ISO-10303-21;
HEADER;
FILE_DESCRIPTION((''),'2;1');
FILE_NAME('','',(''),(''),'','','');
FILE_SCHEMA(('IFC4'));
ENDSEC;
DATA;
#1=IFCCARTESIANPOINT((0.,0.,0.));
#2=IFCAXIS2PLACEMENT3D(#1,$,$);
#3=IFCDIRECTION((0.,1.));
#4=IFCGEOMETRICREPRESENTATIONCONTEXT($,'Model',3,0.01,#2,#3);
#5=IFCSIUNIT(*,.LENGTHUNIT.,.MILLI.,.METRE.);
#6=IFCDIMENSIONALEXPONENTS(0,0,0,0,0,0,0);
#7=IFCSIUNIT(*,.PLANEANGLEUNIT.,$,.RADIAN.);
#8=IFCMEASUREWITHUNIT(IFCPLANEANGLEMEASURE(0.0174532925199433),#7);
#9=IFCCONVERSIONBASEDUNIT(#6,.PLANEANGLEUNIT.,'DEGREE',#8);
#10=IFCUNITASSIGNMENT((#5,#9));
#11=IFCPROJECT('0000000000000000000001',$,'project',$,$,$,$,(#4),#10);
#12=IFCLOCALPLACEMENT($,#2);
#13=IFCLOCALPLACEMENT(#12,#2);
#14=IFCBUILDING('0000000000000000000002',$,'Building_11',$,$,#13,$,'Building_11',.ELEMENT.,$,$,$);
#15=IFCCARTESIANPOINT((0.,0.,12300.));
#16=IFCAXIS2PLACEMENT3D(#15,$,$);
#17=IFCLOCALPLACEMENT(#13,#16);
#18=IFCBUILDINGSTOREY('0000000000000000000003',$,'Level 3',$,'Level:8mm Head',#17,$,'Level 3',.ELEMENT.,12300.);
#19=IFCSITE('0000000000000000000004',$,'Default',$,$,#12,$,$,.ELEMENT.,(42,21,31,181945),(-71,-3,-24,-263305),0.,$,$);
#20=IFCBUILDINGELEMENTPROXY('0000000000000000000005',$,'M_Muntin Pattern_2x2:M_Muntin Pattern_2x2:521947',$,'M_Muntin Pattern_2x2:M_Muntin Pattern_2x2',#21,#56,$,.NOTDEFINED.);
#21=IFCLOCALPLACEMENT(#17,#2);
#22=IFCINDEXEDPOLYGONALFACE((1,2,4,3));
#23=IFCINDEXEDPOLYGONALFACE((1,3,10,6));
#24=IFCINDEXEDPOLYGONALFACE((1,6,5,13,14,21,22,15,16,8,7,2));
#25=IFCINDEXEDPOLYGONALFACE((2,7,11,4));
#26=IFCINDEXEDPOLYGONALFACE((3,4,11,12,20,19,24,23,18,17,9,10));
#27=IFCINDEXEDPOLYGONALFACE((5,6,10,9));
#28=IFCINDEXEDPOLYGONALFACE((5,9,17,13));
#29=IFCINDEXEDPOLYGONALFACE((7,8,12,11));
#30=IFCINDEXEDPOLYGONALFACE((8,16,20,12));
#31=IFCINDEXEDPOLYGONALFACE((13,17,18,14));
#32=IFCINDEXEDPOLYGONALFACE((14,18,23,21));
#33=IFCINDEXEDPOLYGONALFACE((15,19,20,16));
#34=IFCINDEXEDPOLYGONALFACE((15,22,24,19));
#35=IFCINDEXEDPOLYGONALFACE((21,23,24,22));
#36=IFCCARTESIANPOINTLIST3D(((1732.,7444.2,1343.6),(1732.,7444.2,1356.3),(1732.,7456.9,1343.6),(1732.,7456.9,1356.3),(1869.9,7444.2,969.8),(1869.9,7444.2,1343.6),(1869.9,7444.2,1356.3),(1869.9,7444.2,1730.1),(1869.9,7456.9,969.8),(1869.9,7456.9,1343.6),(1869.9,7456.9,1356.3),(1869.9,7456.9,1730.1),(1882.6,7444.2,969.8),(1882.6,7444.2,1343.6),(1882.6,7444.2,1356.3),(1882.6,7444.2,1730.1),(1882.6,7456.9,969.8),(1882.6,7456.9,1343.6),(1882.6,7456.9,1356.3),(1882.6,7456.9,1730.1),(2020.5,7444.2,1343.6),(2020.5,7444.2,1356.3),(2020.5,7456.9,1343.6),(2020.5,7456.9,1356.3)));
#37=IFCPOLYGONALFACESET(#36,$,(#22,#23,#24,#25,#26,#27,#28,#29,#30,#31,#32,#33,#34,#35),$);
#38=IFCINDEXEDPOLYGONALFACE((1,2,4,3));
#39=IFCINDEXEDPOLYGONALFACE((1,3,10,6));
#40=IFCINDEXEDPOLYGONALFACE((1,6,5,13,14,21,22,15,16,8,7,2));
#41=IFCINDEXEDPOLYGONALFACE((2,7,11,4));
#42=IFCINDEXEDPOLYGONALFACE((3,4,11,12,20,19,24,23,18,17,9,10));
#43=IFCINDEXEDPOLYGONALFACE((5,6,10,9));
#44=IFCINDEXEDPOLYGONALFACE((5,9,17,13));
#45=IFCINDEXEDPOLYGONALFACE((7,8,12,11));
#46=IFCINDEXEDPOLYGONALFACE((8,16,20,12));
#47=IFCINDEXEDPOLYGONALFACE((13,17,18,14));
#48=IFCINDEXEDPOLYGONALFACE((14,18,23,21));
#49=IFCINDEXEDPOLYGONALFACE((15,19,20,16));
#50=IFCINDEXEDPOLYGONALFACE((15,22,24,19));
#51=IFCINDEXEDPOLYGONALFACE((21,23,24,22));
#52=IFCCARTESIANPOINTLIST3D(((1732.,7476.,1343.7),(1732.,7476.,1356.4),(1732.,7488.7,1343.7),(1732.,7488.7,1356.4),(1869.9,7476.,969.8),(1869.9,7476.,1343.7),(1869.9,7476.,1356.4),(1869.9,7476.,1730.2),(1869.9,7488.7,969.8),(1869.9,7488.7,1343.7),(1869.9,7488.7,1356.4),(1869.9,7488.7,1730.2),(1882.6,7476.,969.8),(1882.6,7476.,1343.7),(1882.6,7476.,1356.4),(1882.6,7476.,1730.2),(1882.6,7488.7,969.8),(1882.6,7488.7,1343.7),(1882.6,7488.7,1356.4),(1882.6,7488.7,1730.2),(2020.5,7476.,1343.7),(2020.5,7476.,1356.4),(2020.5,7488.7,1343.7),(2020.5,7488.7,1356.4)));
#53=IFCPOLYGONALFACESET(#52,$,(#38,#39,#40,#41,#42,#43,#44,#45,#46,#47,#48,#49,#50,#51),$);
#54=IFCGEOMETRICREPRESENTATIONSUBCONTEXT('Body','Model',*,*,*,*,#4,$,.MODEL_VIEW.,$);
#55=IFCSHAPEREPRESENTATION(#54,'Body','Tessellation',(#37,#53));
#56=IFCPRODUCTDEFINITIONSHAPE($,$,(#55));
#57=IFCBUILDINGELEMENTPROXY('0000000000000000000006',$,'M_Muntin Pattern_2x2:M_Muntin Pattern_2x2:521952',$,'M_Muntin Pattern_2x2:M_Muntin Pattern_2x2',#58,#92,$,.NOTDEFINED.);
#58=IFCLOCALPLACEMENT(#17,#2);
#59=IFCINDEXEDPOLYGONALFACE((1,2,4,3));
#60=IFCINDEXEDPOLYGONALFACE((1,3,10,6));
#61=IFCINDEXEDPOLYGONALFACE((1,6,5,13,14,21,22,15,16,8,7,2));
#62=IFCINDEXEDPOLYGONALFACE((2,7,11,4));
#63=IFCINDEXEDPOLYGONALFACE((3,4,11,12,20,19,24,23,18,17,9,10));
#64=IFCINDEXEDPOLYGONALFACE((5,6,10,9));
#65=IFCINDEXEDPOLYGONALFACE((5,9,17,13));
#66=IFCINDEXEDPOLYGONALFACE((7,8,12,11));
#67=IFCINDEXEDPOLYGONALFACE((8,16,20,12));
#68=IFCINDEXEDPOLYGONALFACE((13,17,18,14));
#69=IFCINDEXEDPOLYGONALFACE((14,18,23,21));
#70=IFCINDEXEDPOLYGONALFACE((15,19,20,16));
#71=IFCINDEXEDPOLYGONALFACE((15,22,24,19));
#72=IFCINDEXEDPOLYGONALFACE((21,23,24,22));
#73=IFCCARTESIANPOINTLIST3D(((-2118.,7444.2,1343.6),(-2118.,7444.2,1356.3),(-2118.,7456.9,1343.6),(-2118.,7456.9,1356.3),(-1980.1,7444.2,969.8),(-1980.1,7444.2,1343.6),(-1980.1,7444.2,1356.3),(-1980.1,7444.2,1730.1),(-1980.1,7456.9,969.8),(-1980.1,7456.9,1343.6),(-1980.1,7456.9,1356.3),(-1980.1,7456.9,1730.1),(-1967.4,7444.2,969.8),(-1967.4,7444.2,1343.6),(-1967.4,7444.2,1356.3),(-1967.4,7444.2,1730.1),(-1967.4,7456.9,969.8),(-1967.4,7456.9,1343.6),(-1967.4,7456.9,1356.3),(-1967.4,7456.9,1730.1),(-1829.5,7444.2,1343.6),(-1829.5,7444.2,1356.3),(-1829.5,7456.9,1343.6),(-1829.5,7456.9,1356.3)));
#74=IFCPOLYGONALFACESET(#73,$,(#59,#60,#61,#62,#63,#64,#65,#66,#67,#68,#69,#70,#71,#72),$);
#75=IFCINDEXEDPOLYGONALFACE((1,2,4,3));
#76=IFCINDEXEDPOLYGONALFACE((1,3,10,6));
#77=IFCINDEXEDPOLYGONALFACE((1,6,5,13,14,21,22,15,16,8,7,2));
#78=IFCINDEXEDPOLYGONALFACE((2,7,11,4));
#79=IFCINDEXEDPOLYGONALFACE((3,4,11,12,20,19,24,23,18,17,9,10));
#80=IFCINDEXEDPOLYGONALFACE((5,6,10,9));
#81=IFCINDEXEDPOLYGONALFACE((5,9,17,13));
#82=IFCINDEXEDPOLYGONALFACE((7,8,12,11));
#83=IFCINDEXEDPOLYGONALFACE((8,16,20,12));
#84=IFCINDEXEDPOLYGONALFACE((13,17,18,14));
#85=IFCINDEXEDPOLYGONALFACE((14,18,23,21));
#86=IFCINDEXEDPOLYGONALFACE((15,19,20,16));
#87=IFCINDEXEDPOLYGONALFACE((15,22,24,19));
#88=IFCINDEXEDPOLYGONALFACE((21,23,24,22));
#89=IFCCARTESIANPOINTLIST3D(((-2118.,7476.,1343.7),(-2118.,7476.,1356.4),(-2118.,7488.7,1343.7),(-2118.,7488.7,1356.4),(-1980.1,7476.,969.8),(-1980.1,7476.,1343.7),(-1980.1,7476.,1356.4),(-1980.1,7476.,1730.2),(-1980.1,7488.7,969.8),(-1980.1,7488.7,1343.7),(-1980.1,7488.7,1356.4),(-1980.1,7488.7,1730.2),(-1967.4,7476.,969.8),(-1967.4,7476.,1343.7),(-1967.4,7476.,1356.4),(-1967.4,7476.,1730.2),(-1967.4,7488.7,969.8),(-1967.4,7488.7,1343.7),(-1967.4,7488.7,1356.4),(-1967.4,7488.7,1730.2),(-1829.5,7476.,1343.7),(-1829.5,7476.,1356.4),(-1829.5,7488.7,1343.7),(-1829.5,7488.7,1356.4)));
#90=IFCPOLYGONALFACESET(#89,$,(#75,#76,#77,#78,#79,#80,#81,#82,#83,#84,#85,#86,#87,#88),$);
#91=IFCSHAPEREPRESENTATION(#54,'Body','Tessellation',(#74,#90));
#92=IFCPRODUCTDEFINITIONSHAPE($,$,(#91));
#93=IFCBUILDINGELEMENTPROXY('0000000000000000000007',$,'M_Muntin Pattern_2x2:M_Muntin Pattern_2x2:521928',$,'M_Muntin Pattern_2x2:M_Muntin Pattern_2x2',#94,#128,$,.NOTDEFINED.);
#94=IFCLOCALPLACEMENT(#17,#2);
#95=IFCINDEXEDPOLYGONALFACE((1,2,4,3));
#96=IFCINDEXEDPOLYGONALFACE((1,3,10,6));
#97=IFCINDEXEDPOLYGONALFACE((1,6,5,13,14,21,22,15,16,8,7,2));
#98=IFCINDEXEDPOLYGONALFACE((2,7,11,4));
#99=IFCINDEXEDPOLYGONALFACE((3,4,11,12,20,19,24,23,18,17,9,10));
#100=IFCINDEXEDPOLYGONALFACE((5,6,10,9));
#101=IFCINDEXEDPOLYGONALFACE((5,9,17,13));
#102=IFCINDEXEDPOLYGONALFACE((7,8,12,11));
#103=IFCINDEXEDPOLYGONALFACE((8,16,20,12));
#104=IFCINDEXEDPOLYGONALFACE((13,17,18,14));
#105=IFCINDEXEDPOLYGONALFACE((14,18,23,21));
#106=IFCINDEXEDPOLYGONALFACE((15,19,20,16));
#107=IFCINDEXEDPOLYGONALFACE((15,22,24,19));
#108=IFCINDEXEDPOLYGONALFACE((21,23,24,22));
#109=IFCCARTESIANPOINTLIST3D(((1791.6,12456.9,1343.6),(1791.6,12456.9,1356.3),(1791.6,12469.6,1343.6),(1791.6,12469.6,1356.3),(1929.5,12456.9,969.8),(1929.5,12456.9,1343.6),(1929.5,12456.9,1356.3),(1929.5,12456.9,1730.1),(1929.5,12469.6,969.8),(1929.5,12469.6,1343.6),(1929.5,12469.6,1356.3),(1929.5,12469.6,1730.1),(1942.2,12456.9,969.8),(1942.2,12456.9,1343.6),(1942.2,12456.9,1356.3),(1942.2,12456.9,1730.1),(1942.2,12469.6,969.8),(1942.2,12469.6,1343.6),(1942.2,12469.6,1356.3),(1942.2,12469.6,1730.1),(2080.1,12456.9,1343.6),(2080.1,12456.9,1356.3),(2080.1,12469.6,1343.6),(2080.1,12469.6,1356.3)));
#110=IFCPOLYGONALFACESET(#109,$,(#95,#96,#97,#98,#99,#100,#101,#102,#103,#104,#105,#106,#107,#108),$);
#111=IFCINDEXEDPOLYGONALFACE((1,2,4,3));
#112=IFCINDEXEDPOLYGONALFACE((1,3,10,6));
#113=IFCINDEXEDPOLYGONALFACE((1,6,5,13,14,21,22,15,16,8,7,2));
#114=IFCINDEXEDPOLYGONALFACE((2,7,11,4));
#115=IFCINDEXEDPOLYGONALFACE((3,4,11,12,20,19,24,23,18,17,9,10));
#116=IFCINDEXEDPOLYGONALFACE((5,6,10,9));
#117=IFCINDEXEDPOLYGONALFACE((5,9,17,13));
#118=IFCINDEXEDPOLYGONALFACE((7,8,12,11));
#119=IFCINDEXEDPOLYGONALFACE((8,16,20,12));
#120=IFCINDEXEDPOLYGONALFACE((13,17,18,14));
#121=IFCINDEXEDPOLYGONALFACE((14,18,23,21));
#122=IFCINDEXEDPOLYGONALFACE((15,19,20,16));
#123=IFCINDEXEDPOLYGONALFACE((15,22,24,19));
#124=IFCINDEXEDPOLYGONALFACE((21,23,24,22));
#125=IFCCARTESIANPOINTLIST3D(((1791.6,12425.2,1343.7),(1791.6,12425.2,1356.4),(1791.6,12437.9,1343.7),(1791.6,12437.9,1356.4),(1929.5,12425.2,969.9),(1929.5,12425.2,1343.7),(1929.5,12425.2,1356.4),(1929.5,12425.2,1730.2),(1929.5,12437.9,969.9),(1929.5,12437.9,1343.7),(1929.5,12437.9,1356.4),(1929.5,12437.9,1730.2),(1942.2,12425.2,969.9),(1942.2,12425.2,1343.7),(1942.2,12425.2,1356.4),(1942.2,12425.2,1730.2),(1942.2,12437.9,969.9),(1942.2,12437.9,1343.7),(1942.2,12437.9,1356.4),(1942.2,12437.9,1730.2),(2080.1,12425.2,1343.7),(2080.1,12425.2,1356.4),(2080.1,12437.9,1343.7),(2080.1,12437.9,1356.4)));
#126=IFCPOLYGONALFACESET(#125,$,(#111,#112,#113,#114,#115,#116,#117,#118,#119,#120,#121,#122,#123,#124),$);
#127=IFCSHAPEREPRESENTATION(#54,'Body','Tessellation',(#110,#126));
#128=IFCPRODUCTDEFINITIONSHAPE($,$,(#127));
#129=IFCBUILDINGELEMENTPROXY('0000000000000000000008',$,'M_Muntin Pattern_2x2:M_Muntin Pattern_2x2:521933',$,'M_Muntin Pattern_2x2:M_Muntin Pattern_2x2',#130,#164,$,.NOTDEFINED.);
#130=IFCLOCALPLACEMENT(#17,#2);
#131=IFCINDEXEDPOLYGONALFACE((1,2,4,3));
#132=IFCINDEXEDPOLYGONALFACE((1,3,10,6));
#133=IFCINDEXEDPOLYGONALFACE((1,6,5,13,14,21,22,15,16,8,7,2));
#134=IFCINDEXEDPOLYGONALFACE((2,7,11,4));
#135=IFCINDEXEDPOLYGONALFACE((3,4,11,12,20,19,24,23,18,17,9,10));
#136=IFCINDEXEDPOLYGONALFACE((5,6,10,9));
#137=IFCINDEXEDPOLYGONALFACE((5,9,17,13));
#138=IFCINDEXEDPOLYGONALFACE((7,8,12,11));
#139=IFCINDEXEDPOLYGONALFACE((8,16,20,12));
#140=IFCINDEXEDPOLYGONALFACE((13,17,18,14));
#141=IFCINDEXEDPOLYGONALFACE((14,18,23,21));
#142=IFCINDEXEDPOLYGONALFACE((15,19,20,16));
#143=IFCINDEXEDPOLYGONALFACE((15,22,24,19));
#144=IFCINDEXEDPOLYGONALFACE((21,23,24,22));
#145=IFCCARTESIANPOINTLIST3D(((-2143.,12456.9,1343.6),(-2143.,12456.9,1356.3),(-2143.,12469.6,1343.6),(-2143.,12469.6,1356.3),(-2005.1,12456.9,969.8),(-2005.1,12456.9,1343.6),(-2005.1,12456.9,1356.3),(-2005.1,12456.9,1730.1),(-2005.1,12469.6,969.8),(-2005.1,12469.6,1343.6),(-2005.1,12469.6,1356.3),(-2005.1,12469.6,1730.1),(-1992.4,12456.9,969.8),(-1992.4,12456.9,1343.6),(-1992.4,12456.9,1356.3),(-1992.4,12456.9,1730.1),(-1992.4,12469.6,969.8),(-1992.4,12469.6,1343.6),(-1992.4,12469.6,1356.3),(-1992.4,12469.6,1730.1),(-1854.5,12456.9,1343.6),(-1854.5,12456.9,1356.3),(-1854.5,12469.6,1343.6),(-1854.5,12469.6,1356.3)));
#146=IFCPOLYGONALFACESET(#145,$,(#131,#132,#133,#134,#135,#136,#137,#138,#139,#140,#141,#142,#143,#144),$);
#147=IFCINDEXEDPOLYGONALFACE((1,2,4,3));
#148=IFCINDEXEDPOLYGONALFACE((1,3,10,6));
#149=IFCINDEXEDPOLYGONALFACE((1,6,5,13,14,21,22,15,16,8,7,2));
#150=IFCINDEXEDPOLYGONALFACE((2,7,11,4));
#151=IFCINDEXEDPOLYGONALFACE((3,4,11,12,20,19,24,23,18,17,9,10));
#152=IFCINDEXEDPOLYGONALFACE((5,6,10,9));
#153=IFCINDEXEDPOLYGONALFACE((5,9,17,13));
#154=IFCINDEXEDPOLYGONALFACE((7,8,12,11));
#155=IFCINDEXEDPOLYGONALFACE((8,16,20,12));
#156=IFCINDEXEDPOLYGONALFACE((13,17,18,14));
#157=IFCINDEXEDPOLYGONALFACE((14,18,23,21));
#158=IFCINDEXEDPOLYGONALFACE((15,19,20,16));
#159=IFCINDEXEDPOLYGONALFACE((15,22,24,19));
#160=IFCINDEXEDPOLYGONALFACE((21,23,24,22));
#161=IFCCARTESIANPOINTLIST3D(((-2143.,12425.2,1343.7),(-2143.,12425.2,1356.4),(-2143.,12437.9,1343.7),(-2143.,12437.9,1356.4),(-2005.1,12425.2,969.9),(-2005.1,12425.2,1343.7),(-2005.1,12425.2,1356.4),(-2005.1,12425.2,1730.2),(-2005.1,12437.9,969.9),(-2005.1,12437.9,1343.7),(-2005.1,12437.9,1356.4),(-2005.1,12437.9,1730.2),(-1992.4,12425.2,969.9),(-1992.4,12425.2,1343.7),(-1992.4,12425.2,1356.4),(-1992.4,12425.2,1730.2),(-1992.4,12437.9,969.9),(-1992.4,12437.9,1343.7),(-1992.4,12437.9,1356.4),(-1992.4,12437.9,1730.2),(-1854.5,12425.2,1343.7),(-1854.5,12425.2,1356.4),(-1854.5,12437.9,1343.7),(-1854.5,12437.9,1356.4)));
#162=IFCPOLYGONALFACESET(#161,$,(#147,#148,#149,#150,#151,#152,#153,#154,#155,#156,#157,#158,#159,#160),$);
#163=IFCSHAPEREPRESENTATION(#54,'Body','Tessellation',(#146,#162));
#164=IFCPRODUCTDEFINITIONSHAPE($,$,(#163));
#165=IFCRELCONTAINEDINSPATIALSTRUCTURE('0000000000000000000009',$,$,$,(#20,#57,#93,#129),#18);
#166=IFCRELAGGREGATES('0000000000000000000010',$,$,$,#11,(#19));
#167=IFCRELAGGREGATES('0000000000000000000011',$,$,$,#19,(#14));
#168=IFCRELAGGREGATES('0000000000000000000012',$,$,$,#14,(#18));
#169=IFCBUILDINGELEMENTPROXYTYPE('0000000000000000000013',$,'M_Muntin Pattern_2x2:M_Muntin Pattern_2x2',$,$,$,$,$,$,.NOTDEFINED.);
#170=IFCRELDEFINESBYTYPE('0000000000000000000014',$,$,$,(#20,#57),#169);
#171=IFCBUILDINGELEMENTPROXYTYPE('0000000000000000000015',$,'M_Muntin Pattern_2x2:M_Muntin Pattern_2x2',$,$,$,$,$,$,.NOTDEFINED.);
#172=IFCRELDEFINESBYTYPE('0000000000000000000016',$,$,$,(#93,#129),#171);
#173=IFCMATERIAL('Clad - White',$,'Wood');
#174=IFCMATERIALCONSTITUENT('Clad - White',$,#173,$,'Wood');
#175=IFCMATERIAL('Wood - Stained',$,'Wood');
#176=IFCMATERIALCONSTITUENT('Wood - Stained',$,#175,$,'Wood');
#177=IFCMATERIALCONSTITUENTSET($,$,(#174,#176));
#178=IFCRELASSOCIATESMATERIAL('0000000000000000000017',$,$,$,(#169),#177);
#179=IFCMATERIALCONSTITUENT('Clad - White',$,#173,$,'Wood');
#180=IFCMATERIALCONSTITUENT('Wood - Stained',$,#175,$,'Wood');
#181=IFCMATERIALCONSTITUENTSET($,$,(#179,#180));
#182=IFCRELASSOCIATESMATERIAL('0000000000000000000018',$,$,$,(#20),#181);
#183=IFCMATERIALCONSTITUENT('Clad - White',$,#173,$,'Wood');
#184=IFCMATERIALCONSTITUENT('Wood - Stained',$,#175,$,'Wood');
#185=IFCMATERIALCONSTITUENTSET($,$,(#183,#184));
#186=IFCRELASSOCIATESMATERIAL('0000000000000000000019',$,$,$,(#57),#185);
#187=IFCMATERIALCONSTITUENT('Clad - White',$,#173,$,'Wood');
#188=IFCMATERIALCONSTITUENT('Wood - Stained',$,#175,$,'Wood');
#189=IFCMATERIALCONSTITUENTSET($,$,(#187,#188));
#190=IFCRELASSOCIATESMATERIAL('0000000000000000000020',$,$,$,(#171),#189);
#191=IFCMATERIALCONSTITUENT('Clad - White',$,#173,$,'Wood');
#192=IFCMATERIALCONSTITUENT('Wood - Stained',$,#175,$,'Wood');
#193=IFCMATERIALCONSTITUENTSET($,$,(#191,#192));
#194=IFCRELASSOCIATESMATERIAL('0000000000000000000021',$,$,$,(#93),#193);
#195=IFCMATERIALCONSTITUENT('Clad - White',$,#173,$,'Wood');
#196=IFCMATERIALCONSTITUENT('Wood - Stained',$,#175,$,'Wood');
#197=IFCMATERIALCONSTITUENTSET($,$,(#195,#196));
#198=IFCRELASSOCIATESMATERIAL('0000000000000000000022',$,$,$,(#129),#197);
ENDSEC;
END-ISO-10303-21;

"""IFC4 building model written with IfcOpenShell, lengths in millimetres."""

from ifc_helpers import new_model, entity, si_unit, converted_unit, direction, frame, origin, place, context, subcontext, project, spatial, indexed_curve, outline, extrude, source, transform, mapped, material, constituent, constituent_set, type_object, type_shapes, element, save


model = new_model("IFC4")

# Units and contexts
model_context = context("Model", 3, precision=0.01, world=origin(), true_north=direction((0.0, 1.0)))
body_context = subcontext(model_context, "Body", "Model", "MODEL_VIEW")
ifc_project = project(units=[si_unit("LENGTHUNIT", "METRE", prefix="MILLI"), converted_unit("PLANEANGLEUNIT", "DEGREE", entity("IfcPlaneAngleMeasure", 0.0174532925199433), si_unit("PLANEANGLEUNIT", "RADIAN"), dimensions=[0, 0, 0, 0, 0, 0, 0])], contexts=[model_context])

# Site, building, storey
site_placement = place(None, origin())
site = spatial("IfcSite", under=ifc_project, at=site_placement, Name="Default", CompositionType="ELEMENT", RefLatitude=(42, 21, 31, 181945), RefLongitude=(-71, -3, -24, -263305), RefElevation=0.0)
building_placement = place(site_placement, origin())
building = spatial("IfcBuilding", under=site, at=building_placement, Name="Building_11", LongName="Building_11", CompositionType="ELEMENT")
storey_placement = place(building_placement, frame((0.0, 0.0, 12300.0)))
storey = spatial("IfcBuildingStorey", under=building, at=storey_placement, Name="Level 3", ObjectType="Level:8mm Head", LongName="Level 3", CompositionType="ELEMENT", Elevation=12300.0)

# Building element proxies
ifc_material_1 = material(Name="Clad - White", Category="Wood")
ifc_material_2 = material(Name="Wood - Stained", Category="Wood")
ifc_constituent_1 = constituent(ifc_material_1, Name="Clad - White", Category="Wood")
ifc_constituent_2 = constituent(ifc_material_2, Name="Wood - Stained", Category="Wood")
ifc_constituent_set_1 = constituent_set(constituents=[ifc_constituent_1, ifc_constituent_2])
building_element_proxy_type_1 = type_object("IfcBuildingElementProxyType", Name="M_Muntin Pattern_2x2:M_Muntin Pattern_2x2", PredefinedType="NOTDEFINED", material=ifc_constituent_set_1)
shared_shape_1 = source(origin(), body_context, "Body", "SweptSolid", [
    extrude(outline(indexed_curve([(6.4, -6.4), (380.1, -6.4), (380.1, 6.3), (6.4, 6.3), (6.4, 144.2), (-6.3, 144.2), (-6.3, 6.3), (-380.2, 6.3), (-380.2, -6.4), (-6.3, -6.4), (-6.3, -144.2), (6.4, -144.2), (6.4, -6.4)], self_intersect=False)), frame((0.0, 9.5, 380.1), z_axis=(0.0, 1.0, 0.0), x_axis=(0.0, 0.0, 1.0)), (0.0, 0.0, 1.0), 12.7),
    extrude(outline(indexed_curve([(6.4, -6.4), (380.2, -6.4), (380.2, 6.3), (6.4, 6.3), (6.4, 144.2), (-6.3, 144.2), (-6.3, 6.3), (-380.2, 6.3), (-380.2, -6.4), (-6.3, -6.4), (-6.3, -144.2), (6.4, -144.2), (6.4, -6.4)], self_intersect=False)), frame((0.0, -22.2, 380.2), z_axis=(0.0, 1.0, 0.0), x_axis=(0.0, 0.0, 1.0)), (0.0, 0.0, 1.0), 12.7),
])
type_shapes(building_element_proxy_type_1, [shared_shape_1])
ifc_constituent_3 = constituent(ifc_material_1, Name="Clad - White", Category="Wood")
ifc_constituent_4 = constituent(ifc_material_2, Name="Wood - Stained", Category="Wood")
ifc_constituent_set_2 = constituent_set(constituents=[ifc_constituent_3, ifc_constituent_4])
proxy_1_placement = place(storey_placement, frame((1876.2, 7466.4, 969.8), z_axis=(0.0, 0.0, 1.0), x_axis=(-1.0, 0.0, 0.0)))
element("IfcBuildingElementProxy", 1, at=proxy_1_placement, inside=storey, type_object=building_element_proxy_type_1, material=ifc_constituent_set_2, Name="M_Muntin Pattern_2x2:M_Muntin Pattern_2x2:521947", ObjectType="M_Muntin Pattern_2x2:M_Muntin Pattern_2x2", PredefinedType="NOTDEFINED", context=body_context, shape_type="MappedRepresentation", body=[
    mapped(shared_shape_1, transform((0.0, 0.0, 0.0), scale=1.0)),
])
ifc_constituent_5 = constituent(ifc_material_1, Name="Clad - White", Category="Wood")
ifc_constituent_6 = constituent(ifc_material_2, Name="Wood - Stained", Category="Wood")
ifc_constituent_set_3 = constituent_set(constituents=[ifc_constituent_5, ifc_constituent_6])
proxy_2_placement = place(storey_placement, frame((-1973.8, 7466.4, 969.8), z_axis=(0.0, 0.0, 1.0), x_axis=(-1.0, 0.0, 0.0)))
element("IfcBuildingElementProxy", 2, at=proxy_2_placement, inside=storey, type_object=building_element_proxy_type_1, material=ifc_constituent_set_3, Name="M_Muntin Pattern_2x2:M_Muntin Pattern_2x2:521952", ObjectType="M_Muntin Pattern_2x2:M_Muntin Pattern_2x2", PredefinedType="NOTDEFINED", context=body_context, shape_type="MappedRepresentation", body=[
    mapped(shared_shape_1, transform((0.0, 0.0, 0.0), scale=1.0)),
])
ifc_constituent_7 = constituent(ifc_material_1, Name="Clad - White", Category="Wood")
ifc_constituent_8 = constituent(ifc_material_2, Name="Wood - Stained", Category="Wood")
ifc_constituent_set_4 = constituent_set(constituents=[ifc_constituent_7, ifc_constituent_8])
ifc_constituent_9 = constituent(ifc_material_1, Name="Clad - White", Category="Wood")
ifc_constituent_10 = constituent(ifc_material_2, Name="Wood - Stained", Category="Wood")
ifc_constituent_set_5 = constituent_set(constituents=[ifc_constituent_9, ifc_constituent_10])
building_element_proxy_type_2 = type_object("IfcBuildingElementProxyType", Name="M_Muntin Pattern_2x2:M_Muntin Pattern_2x2", PredefinedType="NOTDEFINED", material=ifc_constituent_set_5)
shared_shape_2 = source(origin(), body_context, "Body", "SweptSolid", [
    extrude(outline(indexed_curve([(6.4, -6.4), (380.1, -6.4), (380.1, 6.3), (6.4, 6.3), (6.4, 144.2), (-6.3, 144.2), (-6.3, 6.3), (-380.2, 6.3), (-380.2, -6.4), (-6.3, -6.4), (-6.3, -144.2), (6.4, -144.2), (6.4, -6.4)], self_intersect=False)), frame((0.0, -22.2, 380.1), z_axis=(0.0, 1.0, 0.0), x_axis=(0.0, 0.0, 1.0)), (0.0, 0.0, 1.0), 12.7),
    extrude(outline(indexed_curve([(6.4, -6.4), (380.2, -6.4), (380.2, 6.3), (6.4, 6.3), (6.4, 144.2), (-6.3, 144.2), (-6.3, 6.3), (-380.2, 6.3), (-380.2, -6.4), (-6.3, -6.4), (-6.3, -144.2), (6.4, -144.2), (6.4, -6.4)], self_intersect=False)), frame((0.0, 9.5, 380.2), z_axis=(0.0, 1.0, 0.0), x_axis=(0.0, 0.0, 1.0)), (0.0, 0.0, 1.0), 12.7),
])
type_shapes(building_element_proxy_type_2, [shared_shape_2])
proxy_3_placement = place(storey_placement, frame((1935.8, 12447.4, 969.9), z_axis=(0.0, 0.0, 1.0), x_axis=(-1.0, 0.0, 0.0)))
element("IfcBuildingElementProxy", 3, at=proxy_3_placement, inside=storey, type_object=building_element_proxy_type_2, material=ifc_constituent_set_4, Name="M_Muntin Pattern_2x2:M_Muntin Pattern_2x2:521928", ObjectType="M_Muntin Pattern_2x2:M_Muntin Pattern_2x2", PredefinedType="NOTDEFINED", context=body_context, shape_type="MappedRepresentation", body=[
    mapped(shared_shape_2, transform((0.0, 0.0, 0.0), scale=1.0)),
])
ifc_constituent_11 = constituent(ifc_material_1, Name="Clad - White", Category="Wood")
ifc_constituent_12 = constituent(ifc_material_2, Name="Wood - Stained", Category="Wood")
ifc_constituent_set_6 = constituent_set(constituents=[ifc_constituent_11, ifc_constituent_12])
proxy_4_placement = place(storey_placement, frame((-1998.8, 12447.4, 969.9), z_axis=(0.0, 0.0, 1.0), x_axis=(-1.0, 0.0, 0.0)))
element("IfcBuildingElementProxy", 4, at=proxy_4_placement, inside=storey, type_object=building_element_proxy_type_2, material=ifc_constituent_set_6, Name="M_Muntin Pattern_2x2:M_Muntin Pattern_2x2:521933", ObjectType="M_Muntin Pattern_2x2:M_Muntin Pattern_2x2", PredefinedType="NOTDEFINED", context=body_context, shape_type="MappedRepresentation", body=[
    mapped(shared_shape_2, transform((0.0, 0.0, 0.0), scale=1.0)),
])

save(model, "model.ifc")
